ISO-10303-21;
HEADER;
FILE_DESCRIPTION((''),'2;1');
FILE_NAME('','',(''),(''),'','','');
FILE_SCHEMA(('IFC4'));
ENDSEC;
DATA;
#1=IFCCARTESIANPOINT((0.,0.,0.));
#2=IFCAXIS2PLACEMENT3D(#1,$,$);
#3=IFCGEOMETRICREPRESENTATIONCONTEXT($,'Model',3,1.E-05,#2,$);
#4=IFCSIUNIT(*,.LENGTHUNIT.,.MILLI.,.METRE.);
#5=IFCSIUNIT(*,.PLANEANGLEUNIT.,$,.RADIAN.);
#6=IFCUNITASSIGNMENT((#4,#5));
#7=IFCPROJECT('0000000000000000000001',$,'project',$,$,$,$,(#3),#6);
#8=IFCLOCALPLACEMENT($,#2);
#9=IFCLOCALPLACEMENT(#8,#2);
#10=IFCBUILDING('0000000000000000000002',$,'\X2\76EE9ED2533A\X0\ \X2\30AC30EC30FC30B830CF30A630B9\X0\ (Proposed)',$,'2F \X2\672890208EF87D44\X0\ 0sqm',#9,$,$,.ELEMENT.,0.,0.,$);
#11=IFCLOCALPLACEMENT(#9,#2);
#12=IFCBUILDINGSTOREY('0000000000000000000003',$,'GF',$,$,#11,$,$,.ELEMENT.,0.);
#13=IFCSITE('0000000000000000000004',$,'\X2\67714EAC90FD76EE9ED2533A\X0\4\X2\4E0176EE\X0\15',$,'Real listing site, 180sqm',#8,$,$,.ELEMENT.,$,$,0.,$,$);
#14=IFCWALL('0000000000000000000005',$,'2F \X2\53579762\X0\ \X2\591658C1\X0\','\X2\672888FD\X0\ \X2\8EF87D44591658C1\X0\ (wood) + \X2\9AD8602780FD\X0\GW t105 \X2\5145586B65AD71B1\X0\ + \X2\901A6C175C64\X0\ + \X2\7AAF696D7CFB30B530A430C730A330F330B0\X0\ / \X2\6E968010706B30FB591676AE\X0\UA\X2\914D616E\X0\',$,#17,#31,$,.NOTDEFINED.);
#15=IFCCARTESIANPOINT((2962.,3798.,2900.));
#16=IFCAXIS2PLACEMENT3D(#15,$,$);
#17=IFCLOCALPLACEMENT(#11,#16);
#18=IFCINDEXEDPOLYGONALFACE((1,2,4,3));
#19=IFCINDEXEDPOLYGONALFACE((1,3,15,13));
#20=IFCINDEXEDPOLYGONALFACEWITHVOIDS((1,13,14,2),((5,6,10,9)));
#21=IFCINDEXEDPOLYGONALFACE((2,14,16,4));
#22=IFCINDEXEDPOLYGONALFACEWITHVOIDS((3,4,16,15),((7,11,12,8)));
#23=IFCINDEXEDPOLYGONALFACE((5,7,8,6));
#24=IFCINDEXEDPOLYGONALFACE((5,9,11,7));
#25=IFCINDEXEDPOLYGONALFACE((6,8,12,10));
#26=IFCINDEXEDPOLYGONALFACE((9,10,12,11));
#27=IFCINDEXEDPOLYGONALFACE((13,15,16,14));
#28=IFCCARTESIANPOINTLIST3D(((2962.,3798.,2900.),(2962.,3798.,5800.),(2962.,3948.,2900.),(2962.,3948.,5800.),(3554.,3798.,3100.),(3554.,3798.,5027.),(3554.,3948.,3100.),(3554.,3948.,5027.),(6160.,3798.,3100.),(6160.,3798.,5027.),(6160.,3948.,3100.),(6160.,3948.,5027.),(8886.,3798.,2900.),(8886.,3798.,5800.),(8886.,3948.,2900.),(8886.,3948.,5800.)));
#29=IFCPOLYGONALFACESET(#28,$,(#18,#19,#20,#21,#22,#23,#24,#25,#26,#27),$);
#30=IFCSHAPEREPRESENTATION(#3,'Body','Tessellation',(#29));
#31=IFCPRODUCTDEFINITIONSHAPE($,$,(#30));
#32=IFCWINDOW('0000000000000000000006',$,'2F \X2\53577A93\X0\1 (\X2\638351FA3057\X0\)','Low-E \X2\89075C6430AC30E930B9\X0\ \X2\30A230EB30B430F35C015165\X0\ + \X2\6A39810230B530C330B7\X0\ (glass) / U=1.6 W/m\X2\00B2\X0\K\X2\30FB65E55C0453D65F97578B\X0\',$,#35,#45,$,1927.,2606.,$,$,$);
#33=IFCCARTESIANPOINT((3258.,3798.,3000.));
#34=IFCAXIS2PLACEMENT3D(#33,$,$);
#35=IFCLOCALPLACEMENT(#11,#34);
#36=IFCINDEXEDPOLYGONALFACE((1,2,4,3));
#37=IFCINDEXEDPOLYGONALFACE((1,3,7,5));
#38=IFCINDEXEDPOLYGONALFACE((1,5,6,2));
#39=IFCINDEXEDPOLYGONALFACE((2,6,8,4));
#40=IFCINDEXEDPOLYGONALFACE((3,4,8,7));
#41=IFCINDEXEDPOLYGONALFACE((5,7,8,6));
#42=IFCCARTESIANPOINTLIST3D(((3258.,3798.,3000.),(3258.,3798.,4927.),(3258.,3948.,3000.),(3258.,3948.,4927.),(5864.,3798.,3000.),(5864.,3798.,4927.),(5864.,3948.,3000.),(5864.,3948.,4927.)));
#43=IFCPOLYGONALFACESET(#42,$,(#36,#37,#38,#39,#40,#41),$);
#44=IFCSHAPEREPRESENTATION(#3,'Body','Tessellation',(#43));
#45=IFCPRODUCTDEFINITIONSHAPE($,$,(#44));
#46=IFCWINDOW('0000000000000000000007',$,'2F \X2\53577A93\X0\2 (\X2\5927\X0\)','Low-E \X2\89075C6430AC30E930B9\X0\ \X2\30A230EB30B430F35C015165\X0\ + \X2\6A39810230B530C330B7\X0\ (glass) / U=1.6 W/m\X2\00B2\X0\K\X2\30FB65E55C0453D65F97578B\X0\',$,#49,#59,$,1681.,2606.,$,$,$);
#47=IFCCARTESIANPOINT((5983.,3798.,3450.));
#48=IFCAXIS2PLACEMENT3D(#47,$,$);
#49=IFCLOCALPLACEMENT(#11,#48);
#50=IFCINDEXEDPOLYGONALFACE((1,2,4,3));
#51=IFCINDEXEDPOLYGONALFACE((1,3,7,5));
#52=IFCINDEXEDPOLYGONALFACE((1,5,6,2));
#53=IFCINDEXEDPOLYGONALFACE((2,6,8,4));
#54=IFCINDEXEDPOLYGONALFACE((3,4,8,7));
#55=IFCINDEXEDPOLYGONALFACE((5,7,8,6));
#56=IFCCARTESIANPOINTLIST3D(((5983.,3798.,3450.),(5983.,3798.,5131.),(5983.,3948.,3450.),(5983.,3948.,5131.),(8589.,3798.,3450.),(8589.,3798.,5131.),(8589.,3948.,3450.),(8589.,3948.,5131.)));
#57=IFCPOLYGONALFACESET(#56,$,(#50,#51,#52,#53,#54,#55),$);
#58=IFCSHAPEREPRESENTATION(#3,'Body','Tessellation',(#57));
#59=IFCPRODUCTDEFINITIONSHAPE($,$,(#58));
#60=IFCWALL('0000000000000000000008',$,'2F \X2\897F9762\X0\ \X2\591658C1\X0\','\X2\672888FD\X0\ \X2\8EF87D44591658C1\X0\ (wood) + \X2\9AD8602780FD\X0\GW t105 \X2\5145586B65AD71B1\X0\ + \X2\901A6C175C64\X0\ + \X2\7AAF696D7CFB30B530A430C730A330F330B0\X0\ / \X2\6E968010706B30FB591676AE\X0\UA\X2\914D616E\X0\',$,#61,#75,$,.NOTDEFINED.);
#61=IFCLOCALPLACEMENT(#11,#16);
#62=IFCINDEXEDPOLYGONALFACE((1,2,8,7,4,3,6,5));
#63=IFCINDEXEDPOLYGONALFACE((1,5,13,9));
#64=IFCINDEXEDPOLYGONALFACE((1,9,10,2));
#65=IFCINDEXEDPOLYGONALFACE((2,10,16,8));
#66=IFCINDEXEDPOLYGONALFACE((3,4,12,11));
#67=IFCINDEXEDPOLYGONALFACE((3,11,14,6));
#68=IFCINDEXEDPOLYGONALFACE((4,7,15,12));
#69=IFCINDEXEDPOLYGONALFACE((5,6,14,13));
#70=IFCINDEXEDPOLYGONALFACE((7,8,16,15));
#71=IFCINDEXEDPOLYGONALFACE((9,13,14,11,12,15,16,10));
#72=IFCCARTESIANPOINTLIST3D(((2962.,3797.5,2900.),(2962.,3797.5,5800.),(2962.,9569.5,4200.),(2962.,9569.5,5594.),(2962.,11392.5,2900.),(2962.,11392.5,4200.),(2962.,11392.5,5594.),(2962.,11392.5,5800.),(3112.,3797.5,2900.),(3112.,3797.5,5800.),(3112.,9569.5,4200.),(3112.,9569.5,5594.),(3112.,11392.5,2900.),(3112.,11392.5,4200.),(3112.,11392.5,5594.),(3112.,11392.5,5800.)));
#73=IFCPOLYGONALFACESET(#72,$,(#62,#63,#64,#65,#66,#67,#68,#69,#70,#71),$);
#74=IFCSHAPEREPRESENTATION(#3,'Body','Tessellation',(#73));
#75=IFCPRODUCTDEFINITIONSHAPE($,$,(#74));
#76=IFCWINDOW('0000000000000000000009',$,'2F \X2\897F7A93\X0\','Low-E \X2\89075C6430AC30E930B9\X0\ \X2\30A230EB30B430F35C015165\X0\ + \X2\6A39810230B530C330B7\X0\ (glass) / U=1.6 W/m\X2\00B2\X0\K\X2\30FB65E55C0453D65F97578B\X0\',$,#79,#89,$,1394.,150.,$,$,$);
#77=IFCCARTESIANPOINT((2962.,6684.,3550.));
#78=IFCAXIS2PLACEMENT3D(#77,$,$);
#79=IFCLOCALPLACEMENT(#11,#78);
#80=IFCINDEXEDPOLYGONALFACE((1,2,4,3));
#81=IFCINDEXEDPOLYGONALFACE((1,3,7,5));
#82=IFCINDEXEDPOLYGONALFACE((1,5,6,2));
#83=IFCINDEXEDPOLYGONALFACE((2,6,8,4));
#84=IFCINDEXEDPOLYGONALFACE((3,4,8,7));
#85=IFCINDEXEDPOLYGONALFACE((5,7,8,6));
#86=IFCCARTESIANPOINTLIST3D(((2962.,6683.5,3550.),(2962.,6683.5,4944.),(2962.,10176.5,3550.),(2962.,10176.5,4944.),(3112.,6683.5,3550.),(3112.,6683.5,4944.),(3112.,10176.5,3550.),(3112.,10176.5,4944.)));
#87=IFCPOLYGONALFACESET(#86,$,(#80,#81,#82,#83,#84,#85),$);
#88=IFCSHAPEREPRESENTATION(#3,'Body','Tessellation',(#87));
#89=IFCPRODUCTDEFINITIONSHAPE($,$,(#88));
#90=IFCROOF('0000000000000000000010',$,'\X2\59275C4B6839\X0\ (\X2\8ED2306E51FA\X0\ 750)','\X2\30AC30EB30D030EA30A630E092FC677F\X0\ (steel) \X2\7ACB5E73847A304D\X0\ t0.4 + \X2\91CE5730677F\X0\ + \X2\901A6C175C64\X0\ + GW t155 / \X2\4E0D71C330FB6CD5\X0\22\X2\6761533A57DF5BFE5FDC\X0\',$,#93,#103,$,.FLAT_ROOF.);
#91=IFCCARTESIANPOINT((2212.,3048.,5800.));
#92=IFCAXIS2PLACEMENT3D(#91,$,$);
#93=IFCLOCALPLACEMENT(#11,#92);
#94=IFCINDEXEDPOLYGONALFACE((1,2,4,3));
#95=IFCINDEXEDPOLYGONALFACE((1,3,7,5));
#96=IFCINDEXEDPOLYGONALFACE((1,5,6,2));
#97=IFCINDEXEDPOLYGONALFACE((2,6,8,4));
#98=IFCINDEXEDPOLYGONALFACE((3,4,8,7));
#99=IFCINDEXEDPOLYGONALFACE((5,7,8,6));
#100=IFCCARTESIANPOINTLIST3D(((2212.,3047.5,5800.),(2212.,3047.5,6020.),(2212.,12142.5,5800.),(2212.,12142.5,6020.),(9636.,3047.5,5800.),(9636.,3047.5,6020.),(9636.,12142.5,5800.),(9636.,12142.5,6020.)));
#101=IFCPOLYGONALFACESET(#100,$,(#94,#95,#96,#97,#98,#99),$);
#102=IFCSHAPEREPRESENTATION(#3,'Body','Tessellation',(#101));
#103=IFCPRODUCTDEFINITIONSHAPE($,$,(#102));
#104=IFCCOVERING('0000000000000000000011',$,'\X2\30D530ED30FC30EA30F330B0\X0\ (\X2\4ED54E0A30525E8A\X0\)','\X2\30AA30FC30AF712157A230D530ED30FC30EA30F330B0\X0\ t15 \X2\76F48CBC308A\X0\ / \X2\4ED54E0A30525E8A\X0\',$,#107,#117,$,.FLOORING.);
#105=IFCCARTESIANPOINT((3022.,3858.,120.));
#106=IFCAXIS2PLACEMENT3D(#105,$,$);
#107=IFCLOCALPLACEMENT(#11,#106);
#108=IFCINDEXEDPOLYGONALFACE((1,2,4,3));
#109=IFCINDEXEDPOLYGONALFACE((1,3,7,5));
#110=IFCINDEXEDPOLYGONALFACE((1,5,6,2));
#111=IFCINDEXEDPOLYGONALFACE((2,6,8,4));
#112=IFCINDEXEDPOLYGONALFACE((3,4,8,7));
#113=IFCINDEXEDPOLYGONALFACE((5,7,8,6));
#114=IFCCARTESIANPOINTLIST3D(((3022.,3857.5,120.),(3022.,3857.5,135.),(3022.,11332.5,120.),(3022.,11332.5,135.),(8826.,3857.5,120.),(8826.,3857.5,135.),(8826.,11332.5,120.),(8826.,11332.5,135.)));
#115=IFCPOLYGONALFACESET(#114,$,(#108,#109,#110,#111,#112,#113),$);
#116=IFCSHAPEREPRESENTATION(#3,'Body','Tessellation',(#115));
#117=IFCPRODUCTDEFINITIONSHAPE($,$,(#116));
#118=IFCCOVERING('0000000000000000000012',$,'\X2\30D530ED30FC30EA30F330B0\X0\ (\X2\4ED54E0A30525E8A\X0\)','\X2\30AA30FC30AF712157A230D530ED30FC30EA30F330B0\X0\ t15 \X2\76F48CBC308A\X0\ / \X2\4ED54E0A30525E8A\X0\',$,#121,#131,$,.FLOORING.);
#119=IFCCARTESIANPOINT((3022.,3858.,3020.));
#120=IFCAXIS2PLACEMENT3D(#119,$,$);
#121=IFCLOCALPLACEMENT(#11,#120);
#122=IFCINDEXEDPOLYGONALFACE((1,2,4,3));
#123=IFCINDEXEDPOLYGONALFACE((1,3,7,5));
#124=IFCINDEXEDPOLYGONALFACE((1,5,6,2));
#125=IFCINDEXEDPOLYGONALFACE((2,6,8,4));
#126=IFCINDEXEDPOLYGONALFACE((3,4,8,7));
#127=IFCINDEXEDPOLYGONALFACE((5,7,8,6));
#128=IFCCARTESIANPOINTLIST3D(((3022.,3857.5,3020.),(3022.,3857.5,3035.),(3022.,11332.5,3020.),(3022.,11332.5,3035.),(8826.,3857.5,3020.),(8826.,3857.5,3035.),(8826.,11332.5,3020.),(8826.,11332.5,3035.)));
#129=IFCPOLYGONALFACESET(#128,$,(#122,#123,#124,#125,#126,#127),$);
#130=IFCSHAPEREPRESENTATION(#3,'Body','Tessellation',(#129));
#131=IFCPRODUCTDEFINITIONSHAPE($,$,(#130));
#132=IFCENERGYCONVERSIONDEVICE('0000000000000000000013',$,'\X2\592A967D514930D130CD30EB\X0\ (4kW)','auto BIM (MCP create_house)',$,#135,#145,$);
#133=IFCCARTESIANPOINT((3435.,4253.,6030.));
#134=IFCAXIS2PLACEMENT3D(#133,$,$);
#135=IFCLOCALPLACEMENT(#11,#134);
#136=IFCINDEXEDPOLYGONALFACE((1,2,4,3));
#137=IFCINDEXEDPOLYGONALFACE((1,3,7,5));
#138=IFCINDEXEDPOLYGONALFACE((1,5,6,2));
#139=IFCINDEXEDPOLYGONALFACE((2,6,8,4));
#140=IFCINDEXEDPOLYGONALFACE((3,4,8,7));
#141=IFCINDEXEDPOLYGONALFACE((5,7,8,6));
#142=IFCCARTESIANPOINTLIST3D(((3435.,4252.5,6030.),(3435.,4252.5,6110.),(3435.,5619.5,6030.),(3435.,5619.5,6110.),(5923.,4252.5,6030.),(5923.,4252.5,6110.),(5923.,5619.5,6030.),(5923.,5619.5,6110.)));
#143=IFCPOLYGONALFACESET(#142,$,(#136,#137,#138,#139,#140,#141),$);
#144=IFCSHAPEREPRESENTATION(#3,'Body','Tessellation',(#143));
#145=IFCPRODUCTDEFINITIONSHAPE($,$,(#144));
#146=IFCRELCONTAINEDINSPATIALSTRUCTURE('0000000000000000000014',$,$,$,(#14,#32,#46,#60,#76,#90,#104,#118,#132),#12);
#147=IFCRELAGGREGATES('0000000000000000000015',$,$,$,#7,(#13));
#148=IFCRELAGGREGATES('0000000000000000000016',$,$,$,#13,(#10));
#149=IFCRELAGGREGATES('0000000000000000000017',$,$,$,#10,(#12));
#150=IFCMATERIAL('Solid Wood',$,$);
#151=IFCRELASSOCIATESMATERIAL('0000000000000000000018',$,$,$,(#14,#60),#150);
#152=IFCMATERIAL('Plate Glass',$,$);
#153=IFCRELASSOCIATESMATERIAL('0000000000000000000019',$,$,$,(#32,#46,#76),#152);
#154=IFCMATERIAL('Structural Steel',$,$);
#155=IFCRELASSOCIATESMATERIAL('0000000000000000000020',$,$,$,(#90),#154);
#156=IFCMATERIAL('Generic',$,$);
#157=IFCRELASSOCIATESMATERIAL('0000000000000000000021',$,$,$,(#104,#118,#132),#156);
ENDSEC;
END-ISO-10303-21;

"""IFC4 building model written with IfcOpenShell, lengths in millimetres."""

from ifc_helpers import new_model, si_unit, frame, frame_2d, origin, place, context, project, spatial, rectangle, extrude, material, element, fill, save


model = new_model("IFC4")

# Units and contexts
model_context = context("Model", 3, precision=1e-05, world=origin())
ifc_project = project(units=[si_unit("LENGTHUNIT", "METRE", prefix="MILLI"), si_unit("PLANEANGLEUNIT", "RADIAN")], contexts=[model_context])

# Site, building, storey
site_placement = place(None, origin())
site = spatial("IfcSite", under=ifc_project, at=site_placement, Name="東京都目黒区4丁目15", ObjectType="Real listing site, 180sqm", CompositionType="ELEMENT", RefElevation=0.0)
building_placement = place(site_placement, origin())
building = spatial("IfcBuilding", under=site, at=building_placement, Name="目黒区 ガレージハウス (Proposed)", ObjectType="2F 木造軸組 0sqm", CompositionType="ELEMENT", ElevationOfRefHeight=0.0, ElevationOfTerrain=0.0)
storey_placement = place(building_placement, origin())
storey = spatial("IfcBuildingStorey", under=building, at=storey_placement, Name="GF", CompositionType="ELEMENT", Elevation=0.0)

# Shared definitions
ifc_material_1 = material(Name="Solid Wood")

# Shared definitions
ifc_material_2 = material(Name="Plate Glass")

# Wall, openings, windows
wall_1_placement = place(storey_placement, frame((2962.0, 3798.0, 2900.0)))
wall_1 = element("IfcWall", 1, at=wall_1_placement, inside=storey, material=ifc_material_1, Name="2F 南面 外壁", Description="木製 軸組外壁 (wood) + 高性能GW t105 充填断熱 + 通気層 + 窯業系サイディング / 準耐火・外皮UA配慮", PredefinedType="NOTDEFINED", context=model_context, shape_type="SweptSolid", body=[
    extrude(rectangle(XDim=5924.0, YDim=150.0, at=frame_2d((2962.0, 75.0))), frame((2962.0, 3798.0, 2900.0)), (0.0, 0.0, 1.0), 2900.0),
])
opening_1_placement = place(storey_placement, frame((3258.0, 3798.0, 3000.0)))
opening_1 = element("IfcOpeningElement", 2, at=opening_1_placement, cuts=wall_1, PredefinedType="NOTDEFINED", context=model_context, shape_type="SweptSolid", body=[
    extrude(rectangle(XDim=2606.0, YDim=150.0, at=frame_2d((1303.0, 75.0))), frame((3258.0, 3798.0, 3000.0)), (0.0, 0.0, 1.0), 1927.0),
])
opening_2_placement = place(storey_placement, frame((5983.0, 3798.0, 3450.0)))
opening_2 = element("IfcOpeningElement", 3, at=opening_2_placement, cuts=wall_1, PredefinedType="NOTDEFINED", context=model_context, shape_type="SweptSolid", body=[
    extrude(rectangle(XDim=2606.0, YDim=150.0, at=frame_2d((1303.0, 75.0))), frame((5983.0, 3798.0, 3450.0)), (0.0, 0.0, 1.0), 1681.0),
])
window_1_placement = place(storey_placement, frame((3258.0, 3798.0, 3000.0)))
window_1 = element("IfcWindow", 4, at=window_1_placement, inside=storey, material=ifc_material_2, Name="2F 南窓1 (掃出し)", Description="Low-E 複層ガラス アルゴン封入 + 樹脂サッシ (glass) / U=1.6 W/m²K・日射取得型", OverallHeight=1927.0, OverallWidth=2606.0, context=model_context, shape_type="SweptSolid", body=[
    extrude(rectangle(XDim=2606.0, YDim=150.0, at=frame_2d((1303.0, 75.0))), frame((3258.0, 3798.0, 3000.0)), (0.0, 0.0, 1.0), 1927.0),
])
fill(opening_1, window_1)
window_2_placement = place(storey_placement, frame((5983.0, 3798.0, 3450.0)))
window_2 = element("IfcWindow", 5, at=window_2_placement, inside=storey, material=ifc_material_2, Name="2F 南窓2 (大)", Description="Low-E 複層ガラス アルゴン封入 + 樹脂サッシ (glass) / U=1.6 W/m²K・日射取得型", OverallHeight=1681.0, OverallWidth=2606.0, context=model_context, shape_type="SweptSolid", body=[
    extrude(rectangle(XDim=2606.0, YDim=150.0, at=frame_2d((1303.0, 75.0))), frame((5983.0, 3798.0, 3450.0)), (0.0, 0.0, 1.0), 1681.0),
])
fill(opening_2, window_2)

# Wall, opening, window
wall_2_placement = place(storey_placement, frame((2962.0, 3798.0, 2900.0)))
wall_2 = element("IfcWall", 6, at=wall_2_placement, inside=storey, material=ifc_material_1, Name="2F 西面 外壁", Description="木製 軸組外壁 (wood) + 高性能GW t105 充填断熱 + 通気層 + 窯業系サイディング / 準耐火・外皮UA配慮", PredefinedType="NOTDEFINED", context=model_context, shape_type="SweptSolid", body=[
    extrude(rectangle(XDim=150.0, YDim=7595.0, at=frame_2d((75.0, 3797.0))), frame((2962.0, 3798.0, 2900.0)), (0.0, 0.0, 1.0), 2900.0),
])
opening_3_placement = place(storey_placement, frame((2962.0, 6684.0, 3550.0)))
opening_3 = element("IfcOpeningElement", 7, at=opening_3_placement, cuts=wall_2, PredefinedType="NOTDEFINED", context=model_context, shape_type="SweptSolid", body=[
    extrude(rectangle(XDim=150.0, YDim=3493.0, at=frame_2d((75.0, 1746.0))), frame((2962.0, 6684.0, 3550.0)), (0.0, 0.0, 1.0), 1394.0),
])
window_3_placement = place(storey_placement, frame((2962.0, 6684.0, 3550.0)))
window_3 = element("IfcWindow", 8, at=window_3_placement, inside=storey, material=ifc_material_2, Name="2F 西窓", Description="Low-E 複層ガラス アルゴン封入 + 樹脂サッシ (glass) / U=1.6 W/m²K・日射取得型", OverallHeight=1394.0, OverallWidth=150.0, context=model_context, shape_type="SweptSolid", body=[
    extrude(rectangle(XDim=150.0, YDim=3493.0, at=frame_2d((75.0, 1746.0))), frame((2962.0, 6684.0, 3550.0)), (0.0, 0.0, 1.0), 1394.0),
])
fill(opening_3, window_3)

# Roof
ifc_material_3 = material(Name="Structural Steel")
roof_placement = place(storey_placement, frame((2212.0, 3048.0, 5800.0)))
element("IfcRoof", 9, at=roof_placement, inside=storey, material=ifc_material_3, Name="大屋根 (軒の出 750)", Description="ガルバリウム鋼板 (steel) 立平葺き t0.4 + 野地板 + 通気層 + GW t155 / 不燃・法22条区域対応", PredefinedType="FLAT_ROOF", context=model_context, shape_type="SweptSolid", body=[
    extrude(rectangle(XDim=7424.0, YDim=9095.0, at=frame_2d((3712.0, 4547.0))), frame((2212.0, 3048.0, 5800.0)), (0.0, 0.0, 1.0), 220.0),
])

# Coverings
ifc_material_4 = material(Name="Generic")
covering_1_placement = place(storey_placement, frame((3022.0, 3858.0, 120.0)))
element("IfcCovering", 10, at=covering_1_placement, inside=storey, material=ifc_material_4, Name="フローリング (仕上げ床)", Description="オーク無垢フローリング t15 直貼り / 仕上げ床", PredefinedType="FLOORING", context=model_context, shape_type="SweptSolid", body=[
    extrude(rectangle(XDim=5804.0, YDim=7475.0, at=frame_2d((2902.0, 3737.0))), frame((3022.0, 3858.0, 120.0)), (0.0, 0.0, 1.0), 15.0),
])
covering_2_placement = place(storey_placement, frame((3022.0, 3858.0, 3020.0)))
element("IfcCovering", 11, at=covering_2_placement, inside=storey, material=ifc_material_4, Name="フローリング (仕上げ床)", Description="オーク無垢フローリング t15 直貼り / 仕上げ床", PredefinedType="FLOORING", context=model_context, shape_type="SweptSolid", body=[
    extrude(rectangle(XDim=5804.0, YDim=7475.0, at=frame_2d((2902.0, 3737.0))), frame((3022.0, 3858.0, 3020.0)), (0.0, 0.0, 1.0), 15.0),
])

# Energy conversion device
energy_conversion_device_placement = place(storey_placement, frame((3435.0, 4253.0, 6030.0)))
element("IfcEnergyConversionDevice", 12, at=energy_conversion_device_placement, inside=storey, material=ifc_material_4, Name="太陽光パネル (4kW)", Description="auto BIM (MCP create_house)", context=model_context, shape_type="SweptSolid", body=[
    extrude(rectangle(XDim=2488.0, YDim=1367.0, at=frame_2d((1244.0, 683.0))), frame((3435.0, 4253.0, 6030.0)), (0.0, 0.0, 1.0), 80.0),
])

save(model, "model.ifc")
